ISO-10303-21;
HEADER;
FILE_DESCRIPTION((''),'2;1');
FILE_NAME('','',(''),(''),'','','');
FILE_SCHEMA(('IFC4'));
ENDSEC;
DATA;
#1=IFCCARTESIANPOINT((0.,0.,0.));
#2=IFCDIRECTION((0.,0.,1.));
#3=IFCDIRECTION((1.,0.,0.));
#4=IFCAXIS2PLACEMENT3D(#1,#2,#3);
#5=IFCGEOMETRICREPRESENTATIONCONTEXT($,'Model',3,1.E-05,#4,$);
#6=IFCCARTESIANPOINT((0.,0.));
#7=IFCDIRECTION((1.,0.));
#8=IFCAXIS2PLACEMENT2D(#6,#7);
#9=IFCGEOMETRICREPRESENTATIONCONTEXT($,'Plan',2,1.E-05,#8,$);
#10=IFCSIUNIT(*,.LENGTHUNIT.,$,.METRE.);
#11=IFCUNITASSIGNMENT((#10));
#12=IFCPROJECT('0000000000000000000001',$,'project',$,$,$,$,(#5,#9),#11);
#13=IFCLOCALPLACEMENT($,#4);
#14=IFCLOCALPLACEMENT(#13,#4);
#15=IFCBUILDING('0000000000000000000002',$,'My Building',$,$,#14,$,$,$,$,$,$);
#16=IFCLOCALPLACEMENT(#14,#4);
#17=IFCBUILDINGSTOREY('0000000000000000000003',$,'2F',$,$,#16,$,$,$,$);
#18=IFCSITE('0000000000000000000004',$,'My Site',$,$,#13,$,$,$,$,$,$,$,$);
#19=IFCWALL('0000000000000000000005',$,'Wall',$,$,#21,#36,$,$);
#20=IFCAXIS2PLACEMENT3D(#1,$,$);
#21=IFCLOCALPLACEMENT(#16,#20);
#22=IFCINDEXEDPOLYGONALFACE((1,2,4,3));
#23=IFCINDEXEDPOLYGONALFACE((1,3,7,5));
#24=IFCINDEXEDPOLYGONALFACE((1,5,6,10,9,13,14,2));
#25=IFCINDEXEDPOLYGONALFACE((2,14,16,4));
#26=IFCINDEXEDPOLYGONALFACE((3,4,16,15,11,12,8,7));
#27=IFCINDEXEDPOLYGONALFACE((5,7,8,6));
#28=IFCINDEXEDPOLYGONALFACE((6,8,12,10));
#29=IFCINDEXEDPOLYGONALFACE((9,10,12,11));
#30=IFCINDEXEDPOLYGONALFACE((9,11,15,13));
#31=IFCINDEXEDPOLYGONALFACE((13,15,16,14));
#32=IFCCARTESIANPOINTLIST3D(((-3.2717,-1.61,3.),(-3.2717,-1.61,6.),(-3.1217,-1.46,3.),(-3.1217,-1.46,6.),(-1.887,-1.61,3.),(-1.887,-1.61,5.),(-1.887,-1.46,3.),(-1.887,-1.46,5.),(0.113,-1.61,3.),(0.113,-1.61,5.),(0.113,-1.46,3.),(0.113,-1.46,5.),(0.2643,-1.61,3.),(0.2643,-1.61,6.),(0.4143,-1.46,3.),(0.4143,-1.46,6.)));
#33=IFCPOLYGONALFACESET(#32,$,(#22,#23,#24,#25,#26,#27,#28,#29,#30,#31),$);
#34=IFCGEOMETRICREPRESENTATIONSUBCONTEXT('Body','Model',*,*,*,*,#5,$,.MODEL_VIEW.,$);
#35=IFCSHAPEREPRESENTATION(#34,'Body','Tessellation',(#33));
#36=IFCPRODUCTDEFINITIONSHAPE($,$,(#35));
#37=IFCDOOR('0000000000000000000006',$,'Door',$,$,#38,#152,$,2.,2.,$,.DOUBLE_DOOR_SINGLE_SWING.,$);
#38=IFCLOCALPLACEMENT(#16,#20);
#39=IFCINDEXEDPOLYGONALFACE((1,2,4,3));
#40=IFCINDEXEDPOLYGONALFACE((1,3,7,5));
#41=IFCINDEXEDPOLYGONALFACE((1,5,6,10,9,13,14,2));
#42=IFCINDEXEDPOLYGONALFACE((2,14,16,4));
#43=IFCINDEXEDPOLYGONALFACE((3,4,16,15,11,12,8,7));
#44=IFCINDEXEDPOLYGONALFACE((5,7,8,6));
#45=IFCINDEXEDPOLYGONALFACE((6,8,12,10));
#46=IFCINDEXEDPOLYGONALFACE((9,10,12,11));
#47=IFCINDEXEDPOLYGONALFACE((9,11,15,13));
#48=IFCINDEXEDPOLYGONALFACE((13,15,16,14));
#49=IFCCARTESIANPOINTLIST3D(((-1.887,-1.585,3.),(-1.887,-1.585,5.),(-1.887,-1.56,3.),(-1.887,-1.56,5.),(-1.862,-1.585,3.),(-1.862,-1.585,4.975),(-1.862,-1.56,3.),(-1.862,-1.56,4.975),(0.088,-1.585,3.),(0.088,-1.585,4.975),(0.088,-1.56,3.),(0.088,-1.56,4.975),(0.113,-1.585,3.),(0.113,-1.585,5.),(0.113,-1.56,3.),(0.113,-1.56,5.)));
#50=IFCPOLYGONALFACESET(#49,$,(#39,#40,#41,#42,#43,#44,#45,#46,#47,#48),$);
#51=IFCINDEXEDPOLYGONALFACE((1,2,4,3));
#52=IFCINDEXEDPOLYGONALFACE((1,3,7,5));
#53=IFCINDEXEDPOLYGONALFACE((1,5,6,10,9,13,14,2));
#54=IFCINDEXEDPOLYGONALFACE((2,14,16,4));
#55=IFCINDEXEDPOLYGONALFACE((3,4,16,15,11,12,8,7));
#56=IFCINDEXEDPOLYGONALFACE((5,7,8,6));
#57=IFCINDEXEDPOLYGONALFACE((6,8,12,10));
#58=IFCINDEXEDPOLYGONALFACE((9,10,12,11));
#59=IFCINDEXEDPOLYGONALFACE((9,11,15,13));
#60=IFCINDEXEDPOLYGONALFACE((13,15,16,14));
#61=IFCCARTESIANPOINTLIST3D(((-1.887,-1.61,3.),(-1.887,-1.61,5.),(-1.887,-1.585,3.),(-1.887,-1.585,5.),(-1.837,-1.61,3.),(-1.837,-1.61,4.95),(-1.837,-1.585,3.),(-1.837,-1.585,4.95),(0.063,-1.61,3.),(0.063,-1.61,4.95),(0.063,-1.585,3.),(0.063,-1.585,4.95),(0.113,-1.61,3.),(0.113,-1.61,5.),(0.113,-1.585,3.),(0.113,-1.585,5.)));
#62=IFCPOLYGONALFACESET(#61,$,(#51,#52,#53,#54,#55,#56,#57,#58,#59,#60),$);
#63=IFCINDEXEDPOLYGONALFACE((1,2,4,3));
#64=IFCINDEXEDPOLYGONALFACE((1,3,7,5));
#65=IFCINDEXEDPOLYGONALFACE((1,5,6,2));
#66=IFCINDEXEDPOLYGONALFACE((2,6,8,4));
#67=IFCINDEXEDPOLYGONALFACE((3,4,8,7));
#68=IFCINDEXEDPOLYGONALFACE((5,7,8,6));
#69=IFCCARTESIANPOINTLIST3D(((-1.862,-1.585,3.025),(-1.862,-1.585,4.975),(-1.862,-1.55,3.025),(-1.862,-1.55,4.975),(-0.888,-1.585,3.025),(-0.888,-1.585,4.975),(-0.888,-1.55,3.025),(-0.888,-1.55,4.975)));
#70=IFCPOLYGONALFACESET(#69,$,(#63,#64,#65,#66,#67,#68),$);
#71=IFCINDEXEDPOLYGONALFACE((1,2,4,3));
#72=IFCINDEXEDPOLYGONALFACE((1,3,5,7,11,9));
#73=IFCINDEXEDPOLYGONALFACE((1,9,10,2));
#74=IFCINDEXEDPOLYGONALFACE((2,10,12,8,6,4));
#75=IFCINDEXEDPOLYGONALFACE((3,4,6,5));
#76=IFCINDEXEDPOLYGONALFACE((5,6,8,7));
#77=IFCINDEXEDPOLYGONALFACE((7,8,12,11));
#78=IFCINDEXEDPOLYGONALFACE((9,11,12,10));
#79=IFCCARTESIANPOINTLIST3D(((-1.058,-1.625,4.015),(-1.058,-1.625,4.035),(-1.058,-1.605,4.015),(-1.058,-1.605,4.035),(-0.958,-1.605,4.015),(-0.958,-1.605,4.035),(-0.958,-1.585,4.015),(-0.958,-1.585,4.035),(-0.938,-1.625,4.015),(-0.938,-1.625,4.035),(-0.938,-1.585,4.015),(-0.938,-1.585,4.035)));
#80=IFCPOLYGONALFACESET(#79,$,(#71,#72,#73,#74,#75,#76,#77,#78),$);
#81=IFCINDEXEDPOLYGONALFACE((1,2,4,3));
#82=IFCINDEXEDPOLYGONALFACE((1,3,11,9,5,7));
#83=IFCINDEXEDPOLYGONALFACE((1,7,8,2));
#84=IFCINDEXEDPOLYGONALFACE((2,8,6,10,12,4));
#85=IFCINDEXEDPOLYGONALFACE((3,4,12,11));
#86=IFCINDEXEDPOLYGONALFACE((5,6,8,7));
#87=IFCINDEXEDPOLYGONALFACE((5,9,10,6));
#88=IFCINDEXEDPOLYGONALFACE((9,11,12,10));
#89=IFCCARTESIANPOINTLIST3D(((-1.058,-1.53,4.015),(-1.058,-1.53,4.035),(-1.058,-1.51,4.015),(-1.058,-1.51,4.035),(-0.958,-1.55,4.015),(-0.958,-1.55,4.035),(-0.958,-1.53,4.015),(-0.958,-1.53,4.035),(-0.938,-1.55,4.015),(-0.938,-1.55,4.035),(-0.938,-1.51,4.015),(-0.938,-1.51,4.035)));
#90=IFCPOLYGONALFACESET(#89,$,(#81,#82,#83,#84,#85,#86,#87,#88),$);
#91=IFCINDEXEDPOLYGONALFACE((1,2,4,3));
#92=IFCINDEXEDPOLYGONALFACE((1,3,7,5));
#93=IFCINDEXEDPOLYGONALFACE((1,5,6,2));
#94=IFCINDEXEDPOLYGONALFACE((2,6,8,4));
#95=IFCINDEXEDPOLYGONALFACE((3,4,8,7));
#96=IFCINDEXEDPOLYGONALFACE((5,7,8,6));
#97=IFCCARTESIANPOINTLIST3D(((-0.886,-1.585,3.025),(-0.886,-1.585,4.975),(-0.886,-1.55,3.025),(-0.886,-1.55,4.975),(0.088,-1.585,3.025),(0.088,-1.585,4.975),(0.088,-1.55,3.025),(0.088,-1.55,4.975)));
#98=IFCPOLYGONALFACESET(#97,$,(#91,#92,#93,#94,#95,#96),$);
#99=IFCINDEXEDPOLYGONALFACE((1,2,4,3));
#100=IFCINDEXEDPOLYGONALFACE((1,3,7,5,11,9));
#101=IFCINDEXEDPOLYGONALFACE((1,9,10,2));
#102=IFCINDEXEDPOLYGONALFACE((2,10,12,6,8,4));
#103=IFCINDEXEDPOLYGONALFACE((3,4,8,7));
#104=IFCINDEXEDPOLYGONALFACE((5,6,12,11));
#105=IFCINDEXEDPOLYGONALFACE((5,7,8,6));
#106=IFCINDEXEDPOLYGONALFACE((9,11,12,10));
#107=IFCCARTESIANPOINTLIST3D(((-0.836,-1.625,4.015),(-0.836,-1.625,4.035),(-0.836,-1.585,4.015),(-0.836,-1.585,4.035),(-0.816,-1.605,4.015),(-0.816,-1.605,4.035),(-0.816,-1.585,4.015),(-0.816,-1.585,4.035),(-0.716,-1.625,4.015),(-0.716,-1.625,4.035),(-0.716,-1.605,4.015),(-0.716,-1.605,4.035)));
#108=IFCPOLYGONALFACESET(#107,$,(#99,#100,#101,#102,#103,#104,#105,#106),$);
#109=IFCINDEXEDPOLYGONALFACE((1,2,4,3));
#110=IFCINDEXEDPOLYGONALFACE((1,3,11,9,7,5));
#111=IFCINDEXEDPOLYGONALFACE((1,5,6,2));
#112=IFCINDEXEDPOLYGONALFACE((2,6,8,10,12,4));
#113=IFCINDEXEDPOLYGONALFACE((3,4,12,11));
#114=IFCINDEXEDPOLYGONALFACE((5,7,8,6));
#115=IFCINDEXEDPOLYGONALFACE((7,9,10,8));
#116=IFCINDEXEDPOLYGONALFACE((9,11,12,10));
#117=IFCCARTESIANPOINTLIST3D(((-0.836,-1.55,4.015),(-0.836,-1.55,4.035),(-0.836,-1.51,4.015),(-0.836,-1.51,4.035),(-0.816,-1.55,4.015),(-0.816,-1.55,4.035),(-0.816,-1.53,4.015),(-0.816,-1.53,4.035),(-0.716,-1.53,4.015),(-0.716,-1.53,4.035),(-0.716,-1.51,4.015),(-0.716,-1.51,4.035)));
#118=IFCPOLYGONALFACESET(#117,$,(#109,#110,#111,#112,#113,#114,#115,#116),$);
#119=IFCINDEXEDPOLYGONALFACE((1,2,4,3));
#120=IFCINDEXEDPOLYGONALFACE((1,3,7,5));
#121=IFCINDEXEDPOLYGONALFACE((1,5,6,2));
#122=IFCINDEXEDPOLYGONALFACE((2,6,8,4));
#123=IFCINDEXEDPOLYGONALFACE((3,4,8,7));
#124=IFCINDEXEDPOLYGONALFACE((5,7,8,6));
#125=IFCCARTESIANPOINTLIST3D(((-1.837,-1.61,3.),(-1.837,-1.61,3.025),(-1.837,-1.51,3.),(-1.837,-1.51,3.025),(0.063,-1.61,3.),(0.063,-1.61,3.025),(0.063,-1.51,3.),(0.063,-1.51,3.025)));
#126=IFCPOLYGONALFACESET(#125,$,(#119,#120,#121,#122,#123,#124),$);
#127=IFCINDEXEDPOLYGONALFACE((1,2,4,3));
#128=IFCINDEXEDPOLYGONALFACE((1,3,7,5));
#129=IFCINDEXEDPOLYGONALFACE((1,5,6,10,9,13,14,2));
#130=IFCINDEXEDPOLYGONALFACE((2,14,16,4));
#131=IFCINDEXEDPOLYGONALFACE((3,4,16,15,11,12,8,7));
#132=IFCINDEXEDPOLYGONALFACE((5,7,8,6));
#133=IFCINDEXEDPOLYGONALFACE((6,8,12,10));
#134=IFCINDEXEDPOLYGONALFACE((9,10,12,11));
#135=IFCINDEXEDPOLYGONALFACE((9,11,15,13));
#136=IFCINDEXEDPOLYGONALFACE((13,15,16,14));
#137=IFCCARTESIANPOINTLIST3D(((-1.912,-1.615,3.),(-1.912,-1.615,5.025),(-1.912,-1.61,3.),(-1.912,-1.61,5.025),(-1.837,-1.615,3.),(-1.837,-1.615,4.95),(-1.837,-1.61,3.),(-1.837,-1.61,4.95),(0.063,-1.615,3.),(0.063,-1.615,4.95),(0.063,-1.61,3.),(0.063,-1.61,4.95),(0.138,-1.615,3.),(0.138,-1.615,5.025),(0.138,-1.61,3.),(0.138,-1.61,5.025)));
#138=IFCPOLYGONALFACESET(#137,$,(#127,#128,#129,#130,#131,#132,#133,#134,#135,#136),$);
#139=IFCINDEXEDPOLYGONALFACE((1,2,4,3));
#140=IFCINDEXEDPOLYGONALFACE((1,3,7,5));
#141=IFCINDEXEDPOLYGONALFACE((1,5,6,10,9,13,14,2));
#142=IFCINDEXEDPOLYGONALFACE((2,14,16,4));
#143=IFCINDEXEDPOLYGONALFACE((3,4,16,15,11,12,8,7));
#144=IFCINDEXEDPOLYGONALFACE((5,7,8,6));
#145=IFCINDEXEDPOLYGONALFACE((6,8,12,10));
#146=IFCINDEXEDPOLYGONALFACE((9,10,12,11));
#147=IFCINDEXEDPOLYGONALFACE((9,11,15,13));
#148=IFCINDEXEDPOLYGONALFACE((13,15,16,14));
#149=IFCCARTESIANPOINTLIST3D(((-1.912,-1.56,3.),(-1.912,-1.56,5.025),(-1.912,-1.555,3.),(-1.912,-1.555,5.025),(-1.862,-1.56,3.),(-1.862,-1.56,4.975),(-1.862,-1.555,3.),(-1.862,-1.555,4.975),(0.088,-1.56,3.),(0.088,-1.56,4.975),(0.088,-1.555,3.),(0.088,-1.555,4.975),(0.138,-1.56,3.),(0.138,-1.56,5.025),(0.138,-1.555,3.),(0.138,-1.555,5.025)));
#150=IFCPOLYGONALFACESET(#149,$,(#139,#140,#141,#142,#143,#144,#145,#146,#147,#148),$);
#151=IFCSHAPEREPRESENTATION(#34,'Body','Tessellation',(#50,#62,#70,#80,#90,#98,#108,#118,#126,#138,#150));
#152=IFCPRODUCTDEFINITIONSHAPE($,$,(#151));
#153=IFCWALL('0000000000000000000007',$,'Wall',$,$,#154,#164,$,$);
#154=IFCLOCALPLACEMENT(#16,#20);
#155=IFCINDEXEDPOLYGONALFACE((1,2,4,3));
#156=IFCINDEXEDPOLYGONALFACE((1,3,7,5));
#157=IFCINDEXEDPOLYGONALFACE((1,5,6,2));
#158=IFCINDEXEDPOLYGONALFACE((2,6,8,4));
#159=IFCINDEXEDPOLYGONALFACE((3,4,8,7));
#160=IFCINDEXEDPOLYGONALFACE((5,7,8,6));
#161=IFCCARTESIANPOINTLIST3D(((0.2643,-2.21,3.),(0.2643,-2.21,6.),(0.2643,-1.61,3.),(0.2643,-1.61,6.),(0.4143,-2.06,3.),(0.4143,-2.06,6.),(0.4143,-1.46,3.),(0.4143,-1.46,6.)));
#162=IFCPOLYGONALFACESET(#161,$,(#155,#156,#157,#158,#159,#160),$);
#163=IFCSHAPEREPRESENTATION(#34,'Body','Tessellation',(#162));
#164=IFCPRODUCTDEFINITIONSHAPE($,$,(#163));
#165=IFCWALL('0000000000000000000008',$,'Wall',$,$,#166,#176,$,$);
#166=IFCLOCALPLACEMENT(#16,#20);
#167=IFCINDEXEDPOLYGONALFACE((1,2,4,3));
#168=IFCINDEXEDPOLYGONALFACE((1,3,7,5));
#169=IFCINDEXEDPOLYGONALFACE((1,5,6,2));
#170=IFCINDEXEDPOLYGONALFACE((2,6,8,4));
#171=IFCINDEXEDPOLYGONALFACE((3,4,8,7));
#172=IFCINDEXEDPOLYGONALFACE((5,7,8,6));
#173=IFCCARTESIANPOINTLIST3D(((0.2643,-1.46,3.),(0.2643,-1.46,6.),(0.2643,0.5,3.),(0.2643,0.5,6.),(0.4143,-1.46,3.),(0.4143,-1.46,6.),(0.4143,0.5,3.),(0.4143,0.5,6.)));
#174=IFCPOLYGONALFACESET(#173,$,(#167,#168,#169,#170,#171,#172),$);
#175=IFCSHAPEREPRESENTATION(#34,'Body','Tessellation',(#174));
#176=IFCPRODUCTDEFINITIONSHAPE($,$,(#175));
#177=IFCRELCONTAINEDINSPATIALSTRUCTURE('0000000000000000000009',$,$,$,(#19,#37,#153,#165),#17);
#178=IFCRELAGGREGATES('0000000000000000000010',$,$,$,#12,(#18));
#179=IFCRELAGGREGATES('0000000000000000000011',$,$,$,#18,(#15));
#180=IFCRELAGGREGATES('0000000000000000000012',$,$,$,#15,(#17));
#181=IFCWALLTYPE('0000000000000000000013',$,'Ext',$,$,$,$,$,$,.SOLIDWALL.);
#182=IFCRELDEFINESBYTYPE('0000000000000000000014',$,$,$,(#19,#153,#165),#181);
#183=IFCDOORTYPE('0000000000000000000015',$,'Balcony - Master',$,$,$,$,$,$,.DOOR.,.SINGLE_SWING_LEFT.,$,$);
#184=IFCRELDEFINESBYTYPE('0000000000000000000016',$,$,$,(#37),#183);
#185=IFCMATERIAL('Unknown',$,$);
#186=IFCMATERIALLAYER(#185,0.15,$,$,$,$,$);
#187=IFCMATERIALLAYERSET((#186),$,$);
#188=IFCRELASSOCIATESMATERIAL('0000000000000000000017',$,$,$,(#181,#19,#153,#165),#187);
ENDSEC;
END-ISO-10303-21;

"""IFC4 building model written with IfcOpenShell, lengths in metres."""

from ifc_helpers import new_model, entity, si_unit, frame, origin_with_axes, origin_2d_with_axis, place, context, subcontext, project, spatial, line, indexed_curve, outline, extrude, shape, source, transform, mapped, material, layer, layer_set, layer_usage, type_object, type_shapes, element, fill, save


model = new_model("IFC4")

# Units and contexts
model_context = context("Model", 3, precision=1e-05, world=origin_with_axes())
plan_context = context("Plan", 2, precision=1e-05, world=origin_2d_with_axis())
body_context_1 = subcontext(model_context, "Body", "Model", "MODEL_VIEW")
body_context_2 = subcontext(plan_context, "Body", "Plan", "PLAN_VIEW")
ifc_project = project(units=[si_unit("LENGTHUNIT", "METRE")], contexts=[model_context, plan_context])

# Site, building, storey
site_placement = place(None, origin_with_axes())
site = spatial("IfcSite", under=ifc_project, at=site_placement, Name="My Site")
building_placement = place(site_placement, origin_with_axes())
building = spatial("IfcBuilding", under=site, at=building_placement, Name="My Building")
storey_placement = place(building_placement, origin_with_axes())
storey = spatial("IfcBuildingStorey", under=building, at=storey_placement, Name="2F")

# Shared definitions
ifc_material = material(Name="Unknown")
ifc_layer_1 = layer(ifc_material, 0.15)
ifc_layer_set_1 = layer_set([ifc_layer_1])
wall_type_1 = type_object("IfcWallType", Name="Ext", PredefinedType="SOLIDWALL", material=ifc_layer_set_1)

# Wall, opening, door
ifc_layer_usage_1 = layer_usage(ifc_layer_set_1, "AXIS2", "POSITIVE", 0.0)
wall_1_placement = place(storey_placement, frame((-3.2717, -1.61, 3.0), z_axis=(0.0, 0.0, 1.0), x_axis=(1.0, 0.0, 0.0)))
wall_1 = element("IfcWall", 1, at=wall_1_placement, inside=storey, type_object=wall_type_1, material=ifc_layer_usage_1, Name="Wall", context=body_context_1, shape_type="SweptSolid", body=[
    extrude(outline(indexed_curve([(0.0, 0.0), (0.15, 0.15), (3.686, 0.15), (3.536, 0.0)], segments=[line(1, 2, 3, 4, 1)])), origin_with_axes(), (0.0, 0.0, 1.0), 3.0),
])
shared_shape_1 = source(origin_with_axes(), body_context_1, "Body", "SweptSolid", [
    extrude(outline(indexed_curve([(0.0, 0.0), (2.0, 0.0), (2.0, 2.0), (0.0, 2.0)], segments=[line(1, 2, 3, 4, 1)])), frame((0.0, -0.6, 0.0), z_axis=(0.0, -1.0, 0.0), x_axis=(1.0, 0.0, 0.0)), (0.0, 0.0, -1.0), 1.2),
])
opening_1_placement = place(wall_1_placement, frame((1.3847, 0.0, 0.0), z_axis=(0.0, 0.0, 1.0), x_axis=(1.0, 0.0, 0.0)))
opening_1 = element("IfcOpeningElement", 2, at=opening_1_placement, cuts=wall_1, PredefinedType="OPENING", context=body_context_1, shape_type="MappedRepresentation", body=[
    mapped(shared_shape_1, transform((0.0, 0.0, 0.0), x_axis=(1.0, 0.0, 0.0), y_axis=(0.0, 1.0, 0.0), z_axis=(0.0, 0.0, 1.0), scale=1.0)),
])
door_type_1 = type_object("IfcDoorType", Name="Balcony - Master", OperationType="SINGLE_SWING_LEFT", PredefinedType="DOOR")
shared_shape_2 = source(origin_with_axes(), body_context_1, "Body", "SweptSolid", [
    extrude(outline(indexed_curve([(0.0, 0.0), (0.0, 2.0), (2.0, 2.0), (2.0, 0.0), (1.975, 0.0), (1.975, 1.975), (0.025, 1.975), (0.025, 0.0)], segments=[line(1, 2, 3, 4, 5, 6, 7, 8, 1)])), frame((0.0, 0.025, 0.0), z_axis=(0.0, -1.0, 0.0), x_axis=(1.0, 0.0, 0.0)), (0.0, 0.0, -1.0), 0.025),
    extrude(outline(indexed_curve([(0.0, 0.0), (0.0, 2.0), (2.0, 2.0), (2.0, 0.0), (1.95, 0.0), (1.95, 1.95), (0.05, 1.95), (0.05, 0.0)], segments=[line(1, 2, 3, 4, 5, 6, 7, 8, 1)])), frame((0.0, 0.0, 0.0), z_axis=(0.0, -1.0, 0.0), x_axis=(1.0, 0.0, 0.0)), (0.0, 0.0, -1.0), 0.025),
    extrude(outline(indexed_curve([(0.0, 0.0), (0.974, 0.0), (0.974, 0.035), (0.0, 0.035)], segments=[line(1, 2, 3, 4, 1)])), frame((0.025, 0.025, 0.025), z_axis=(0.0, 0.0, 1.0), x_axis=(1.0, 0.0, 0.0)), (0.0, 0.0, 1.0), 1.95),
    extrude(outline(indexed_curve([(0.0, 0.0), (0.0, -0.04), (-0.12, -0.04), (-0.12, -0.02), (-0.02, -0.02), (-0.02, 0.0)], segments=[line(1, 2, 3, 4, 5, 6, 1)])), frame((0.949, 0.025, 1.015), z_axis=(0.0, 0.0, 1.0), x_axis=(1.0, 0.0, 0.0)), (0.0, 0.0, 1.0), 0.02),
    extrude(outline(indexed_curve([(0.0, 0.0), (0.0, 0.04), (-0.12, 0.04), (-0.12, 0.02), (-0.02, 0.02), (-0.02, 0.0)], segments=[line(1, 2, 3, 4, 5, 6, 1)])), frame((0.949, 0.06, 1.015), z_axis=(0.0, 0.0, 1.0), x_axis=(1.0, 0.0, 0.0)), (0.0, 0.0, 1.0), 0.02),
    extrude(outline(indexed_curve([(0.0, 0.0), (-0.974, 0.0), (-0.974, 0.035), (0.0, 0.035)], segments=[line(1, 2, 3, 4, 1)])), frame((1.975, 0.025, 0.025), z_axis=(0.0, 0.0, 1.0), x_axis=(1.0, 0.0, 0.0)), (0.0, 0.0, 1.0), 1.95),
    extrude(outline(indexed_curve([(0.0, 0.0), (0.0, -0.04), (0.12, -0.04), (0.12, -0.02), (0.02, -0.02), (0.02, 0.0)], segments=[line(1, 2, 3, 4, 5, 6, 1)])), frame((1.051, 0.025, 1.015), z_axis=(0.0, 0.0, 1.0), x_axis=(1.0, 0.0, 0.0)), (0.0, 0.0, 1.0), 0.02),
    extrude(outline(indexed_curve([(0.0, 0.0), (0.0, 0.04), (0.12, 0.04), (0.12, 0.02), (0.02, 0.02), (0.02, 0.0)], segments=[line(1, 2, 3, 4, 5, 6, 1)])), frame((1.051, 0.06, 1.015), z_axis=(0.0, 0.0, 1.0), x_axis=(1.0, 0.0, 0.0)), (0.0, 0.0, 1.0), 0.02),
    extrude(outline(indexed_curve([(0.0, 0.0), (1.9, 0.0), (1.9, 0.1), (0.0, 0.1)], segments=[line(1, 2, 3, 4, 1)])), frame((0.05, 0.0, 0.0), z_axis=(0.0, 0.0, 1.0), x_axis=(1.0, 0.0, 0.0)), (0.0, 0.0, 1.0), 0.025),
    extrude(outline(indexed_curve([(0.0, 0.0), (0.0, 2.025), (2.05, 2.025), (2.05, 0.0), (1.975, 0.0), (1.975, 1.95), (0.075, 1.95), (0.075, 0.0)], segments=[line(1, 2, 3, 4, 5, 6, 7, 8, 1)])), frame((-0.025, -0.005, 0.0), z_axis=(0.0, -1.0, 0.0), x_axis=(1.0, 0.0, 0.0)), (0.0, 0.0, -1.0), 0.005),
    extrude(outline(indexed_curve([(0.0, 0.0), (0.0, 2.025), (2.05, 2.025), (2.05, 0.0), (2.0, 0.0), (2.0, 1.975), (0.05, 1.975), (0.05, 0.0)], segments=[line(1, 2, 3, 4, 5, 6, 7, 8, 1)])), frame((-0.025, 0.05, 0.0), z_axis=(0.0, -1.0, 0.0), x_axis=(1.0, 0.0, 0.0)), (0.0, 0.0, -1.0), 0.005),
])
shared_shape_3 = source(origin_with_axes(), body_context_2, "Body", "Curve2D", [
    entity("IfcIndexedPolyCurve", entity("IfcCartesianPointList2D", [[0.0, 0.0], [0.0, 0.05], [0.025, 0.05], [0.025, 0.025], [0.05, 0.025], [0.05, 0.0]]), [entity("IfcLineIndex", [1, 2, 3, 4, 5, 6, 1])]),
    entity("IfcIndexedPolyCurve", entity("IfcCartesianPointList2D", [[2.0, 0.0], [2.0, 0.05], [1.975, 0.05], [1.975, 0.025], [1.95, 0.025], [1.95, 0.0]]), [entity("IfcLineIndex", [1, 2, 3, 4, 5, 6, 1])]),
    entity("IfcTrimmedCurve", entity("IfcEllipse", entity("IfcAxis2Placement2D", entity("IfcCartesianPoint", [0.06, 0.05]), entity("IfcDirection", [1.0, 0.0])), 0.94, 0.975), [entity("IfcCartesianPoint", [1.0, 0.05])], [entity("IfcCartesianPoint", [0.06, 1.025])], True, "CARTESIAN"),
    entity("IfcIndexedPolyCurve", entity("IfcCartesianPointList2D", [[0.025, 0.05], [0.06, 0.05], [0.06, 1.025], [0.025, 1.025]]), [entity("IfcLineIndex", [1, 2, 3, 4, 1])]),
    entity("IfcTrimmedCurve", entity("IfcEllipse", entity("IfcAxis2Placement2D", entity("IfcCartesianPoint", [1.94, 0.05]), entity("IfcDirection", [1.0, 0.0])), 0.94, 0.975), [entity("IfcCartesianPoint", [1.94, 1.025])], [entity("IfcCartesianPoint", [1.0, 0.05])], True, "CARTESIAN"),
    entity("IfcIndexedPolyCurve", entity("IfcCartesianPointList2D", [[1.975, 0.05], [1.94, 0.05], [1.94, 1.025], [1.975, 1.025]]), [entity("IfcLineIndex", [1, 2, 3, 4, 1])]),
])
type_shapes(door_type_1, [shared_shape_2, shared_shape_3])
door_1_placement = place(opening_1_placement, frame((0.0, 0.0, 0.0), z_axis=(0.0, 0.0, 1.0), x_axis=(1.0, 0.0, 0.0)))
door_1 = element("IfcDoor", 3, at=door_1_placement, inside=storey, type_object=door_type_1, Name="Door", OperationType="DOUBLE_DOOR_SINGLE_SWING", OverallHeight=2.0, OverallWidth=2.0, shapes=[
    shape(body_context_1, "Body", "MappedRepresentation", [mapped(shared_shape_2, transform((0.0, 0.0, 0.0), x_axis=(1.0, 0.0, 0.0), y_axis=(0.0, 1.0, 0.0), z_axis=(0.0, 0.0, 1.0), scale=1.0))]),
    shape(body_context_2, "Body", "MappedRepresentation", [mapped(shared_shape_3, transform((0.0, 0.0, 0.0), x_axis=(1.0, 0.0, 0.0), y_axis=(0.0, 1.0, 0.0), z_axis=(0.0, 0.0, 1.0), scale=1.0))]),
])
fill(opening_1, door_1)

# Walls
ifc_layer_usage_2 = layer_usage(ifc_layer_set_1, "AXIS2", "POSITIVE", 0.0)
wall_2_placement = place(storey_placement, frame((0.2643, -1.61, 3.0), z_axis=(0.0, 0.0, 1.0), x_axis=(0.0, -1.0, 0.0)))
element("IfcWall", 4, at=wall_2_placement, inside=storey, type_object=wall_type_1, material=ifc_layer_usage_2, Name="Wall", context=body_context_1, shape_type="SweptSolid", body=[
    extrude(outline(indexed_curve([(0.0, 0.0), (-0.15, 0.15), (0.45, 0.15), (0.6, 0.0)], segments=[line(1, 2, 3, 4, 1)])), origin_with_axes(), (0.0, 0.0, 1.0), 3.0),
])
ifc_layer_usage_3 = layer_usage(ifc_layer_set_1, "AXIS2", "POSITIVE", 0.0)
wall_3_placement = place(storey_placement, frame((0.4143, -1.46, 3.0), z_axis=(0.0, 0.0, 1.0), x_axis=(0.0, 1.0, 0.0)))
element("IfcWall", 5, at=wall_3_placement, inside=storey, type_object=wall_type_1, material=ifc_layer_usage_3, Name="Wall", context=body_context_1, shape_type="SweptSolid", body=[
    extrude(outline(indexed_curve([(0.0, 0.0), (0.0, 0.15), (1.96, 0.15), (1.96, 0.0)], segments=[line(1, 2, 3, 4, 1)])), origin_with_axes(), (0.0, 0.0, 1.0), 3.0),
])

save(model, "model.ifc")
